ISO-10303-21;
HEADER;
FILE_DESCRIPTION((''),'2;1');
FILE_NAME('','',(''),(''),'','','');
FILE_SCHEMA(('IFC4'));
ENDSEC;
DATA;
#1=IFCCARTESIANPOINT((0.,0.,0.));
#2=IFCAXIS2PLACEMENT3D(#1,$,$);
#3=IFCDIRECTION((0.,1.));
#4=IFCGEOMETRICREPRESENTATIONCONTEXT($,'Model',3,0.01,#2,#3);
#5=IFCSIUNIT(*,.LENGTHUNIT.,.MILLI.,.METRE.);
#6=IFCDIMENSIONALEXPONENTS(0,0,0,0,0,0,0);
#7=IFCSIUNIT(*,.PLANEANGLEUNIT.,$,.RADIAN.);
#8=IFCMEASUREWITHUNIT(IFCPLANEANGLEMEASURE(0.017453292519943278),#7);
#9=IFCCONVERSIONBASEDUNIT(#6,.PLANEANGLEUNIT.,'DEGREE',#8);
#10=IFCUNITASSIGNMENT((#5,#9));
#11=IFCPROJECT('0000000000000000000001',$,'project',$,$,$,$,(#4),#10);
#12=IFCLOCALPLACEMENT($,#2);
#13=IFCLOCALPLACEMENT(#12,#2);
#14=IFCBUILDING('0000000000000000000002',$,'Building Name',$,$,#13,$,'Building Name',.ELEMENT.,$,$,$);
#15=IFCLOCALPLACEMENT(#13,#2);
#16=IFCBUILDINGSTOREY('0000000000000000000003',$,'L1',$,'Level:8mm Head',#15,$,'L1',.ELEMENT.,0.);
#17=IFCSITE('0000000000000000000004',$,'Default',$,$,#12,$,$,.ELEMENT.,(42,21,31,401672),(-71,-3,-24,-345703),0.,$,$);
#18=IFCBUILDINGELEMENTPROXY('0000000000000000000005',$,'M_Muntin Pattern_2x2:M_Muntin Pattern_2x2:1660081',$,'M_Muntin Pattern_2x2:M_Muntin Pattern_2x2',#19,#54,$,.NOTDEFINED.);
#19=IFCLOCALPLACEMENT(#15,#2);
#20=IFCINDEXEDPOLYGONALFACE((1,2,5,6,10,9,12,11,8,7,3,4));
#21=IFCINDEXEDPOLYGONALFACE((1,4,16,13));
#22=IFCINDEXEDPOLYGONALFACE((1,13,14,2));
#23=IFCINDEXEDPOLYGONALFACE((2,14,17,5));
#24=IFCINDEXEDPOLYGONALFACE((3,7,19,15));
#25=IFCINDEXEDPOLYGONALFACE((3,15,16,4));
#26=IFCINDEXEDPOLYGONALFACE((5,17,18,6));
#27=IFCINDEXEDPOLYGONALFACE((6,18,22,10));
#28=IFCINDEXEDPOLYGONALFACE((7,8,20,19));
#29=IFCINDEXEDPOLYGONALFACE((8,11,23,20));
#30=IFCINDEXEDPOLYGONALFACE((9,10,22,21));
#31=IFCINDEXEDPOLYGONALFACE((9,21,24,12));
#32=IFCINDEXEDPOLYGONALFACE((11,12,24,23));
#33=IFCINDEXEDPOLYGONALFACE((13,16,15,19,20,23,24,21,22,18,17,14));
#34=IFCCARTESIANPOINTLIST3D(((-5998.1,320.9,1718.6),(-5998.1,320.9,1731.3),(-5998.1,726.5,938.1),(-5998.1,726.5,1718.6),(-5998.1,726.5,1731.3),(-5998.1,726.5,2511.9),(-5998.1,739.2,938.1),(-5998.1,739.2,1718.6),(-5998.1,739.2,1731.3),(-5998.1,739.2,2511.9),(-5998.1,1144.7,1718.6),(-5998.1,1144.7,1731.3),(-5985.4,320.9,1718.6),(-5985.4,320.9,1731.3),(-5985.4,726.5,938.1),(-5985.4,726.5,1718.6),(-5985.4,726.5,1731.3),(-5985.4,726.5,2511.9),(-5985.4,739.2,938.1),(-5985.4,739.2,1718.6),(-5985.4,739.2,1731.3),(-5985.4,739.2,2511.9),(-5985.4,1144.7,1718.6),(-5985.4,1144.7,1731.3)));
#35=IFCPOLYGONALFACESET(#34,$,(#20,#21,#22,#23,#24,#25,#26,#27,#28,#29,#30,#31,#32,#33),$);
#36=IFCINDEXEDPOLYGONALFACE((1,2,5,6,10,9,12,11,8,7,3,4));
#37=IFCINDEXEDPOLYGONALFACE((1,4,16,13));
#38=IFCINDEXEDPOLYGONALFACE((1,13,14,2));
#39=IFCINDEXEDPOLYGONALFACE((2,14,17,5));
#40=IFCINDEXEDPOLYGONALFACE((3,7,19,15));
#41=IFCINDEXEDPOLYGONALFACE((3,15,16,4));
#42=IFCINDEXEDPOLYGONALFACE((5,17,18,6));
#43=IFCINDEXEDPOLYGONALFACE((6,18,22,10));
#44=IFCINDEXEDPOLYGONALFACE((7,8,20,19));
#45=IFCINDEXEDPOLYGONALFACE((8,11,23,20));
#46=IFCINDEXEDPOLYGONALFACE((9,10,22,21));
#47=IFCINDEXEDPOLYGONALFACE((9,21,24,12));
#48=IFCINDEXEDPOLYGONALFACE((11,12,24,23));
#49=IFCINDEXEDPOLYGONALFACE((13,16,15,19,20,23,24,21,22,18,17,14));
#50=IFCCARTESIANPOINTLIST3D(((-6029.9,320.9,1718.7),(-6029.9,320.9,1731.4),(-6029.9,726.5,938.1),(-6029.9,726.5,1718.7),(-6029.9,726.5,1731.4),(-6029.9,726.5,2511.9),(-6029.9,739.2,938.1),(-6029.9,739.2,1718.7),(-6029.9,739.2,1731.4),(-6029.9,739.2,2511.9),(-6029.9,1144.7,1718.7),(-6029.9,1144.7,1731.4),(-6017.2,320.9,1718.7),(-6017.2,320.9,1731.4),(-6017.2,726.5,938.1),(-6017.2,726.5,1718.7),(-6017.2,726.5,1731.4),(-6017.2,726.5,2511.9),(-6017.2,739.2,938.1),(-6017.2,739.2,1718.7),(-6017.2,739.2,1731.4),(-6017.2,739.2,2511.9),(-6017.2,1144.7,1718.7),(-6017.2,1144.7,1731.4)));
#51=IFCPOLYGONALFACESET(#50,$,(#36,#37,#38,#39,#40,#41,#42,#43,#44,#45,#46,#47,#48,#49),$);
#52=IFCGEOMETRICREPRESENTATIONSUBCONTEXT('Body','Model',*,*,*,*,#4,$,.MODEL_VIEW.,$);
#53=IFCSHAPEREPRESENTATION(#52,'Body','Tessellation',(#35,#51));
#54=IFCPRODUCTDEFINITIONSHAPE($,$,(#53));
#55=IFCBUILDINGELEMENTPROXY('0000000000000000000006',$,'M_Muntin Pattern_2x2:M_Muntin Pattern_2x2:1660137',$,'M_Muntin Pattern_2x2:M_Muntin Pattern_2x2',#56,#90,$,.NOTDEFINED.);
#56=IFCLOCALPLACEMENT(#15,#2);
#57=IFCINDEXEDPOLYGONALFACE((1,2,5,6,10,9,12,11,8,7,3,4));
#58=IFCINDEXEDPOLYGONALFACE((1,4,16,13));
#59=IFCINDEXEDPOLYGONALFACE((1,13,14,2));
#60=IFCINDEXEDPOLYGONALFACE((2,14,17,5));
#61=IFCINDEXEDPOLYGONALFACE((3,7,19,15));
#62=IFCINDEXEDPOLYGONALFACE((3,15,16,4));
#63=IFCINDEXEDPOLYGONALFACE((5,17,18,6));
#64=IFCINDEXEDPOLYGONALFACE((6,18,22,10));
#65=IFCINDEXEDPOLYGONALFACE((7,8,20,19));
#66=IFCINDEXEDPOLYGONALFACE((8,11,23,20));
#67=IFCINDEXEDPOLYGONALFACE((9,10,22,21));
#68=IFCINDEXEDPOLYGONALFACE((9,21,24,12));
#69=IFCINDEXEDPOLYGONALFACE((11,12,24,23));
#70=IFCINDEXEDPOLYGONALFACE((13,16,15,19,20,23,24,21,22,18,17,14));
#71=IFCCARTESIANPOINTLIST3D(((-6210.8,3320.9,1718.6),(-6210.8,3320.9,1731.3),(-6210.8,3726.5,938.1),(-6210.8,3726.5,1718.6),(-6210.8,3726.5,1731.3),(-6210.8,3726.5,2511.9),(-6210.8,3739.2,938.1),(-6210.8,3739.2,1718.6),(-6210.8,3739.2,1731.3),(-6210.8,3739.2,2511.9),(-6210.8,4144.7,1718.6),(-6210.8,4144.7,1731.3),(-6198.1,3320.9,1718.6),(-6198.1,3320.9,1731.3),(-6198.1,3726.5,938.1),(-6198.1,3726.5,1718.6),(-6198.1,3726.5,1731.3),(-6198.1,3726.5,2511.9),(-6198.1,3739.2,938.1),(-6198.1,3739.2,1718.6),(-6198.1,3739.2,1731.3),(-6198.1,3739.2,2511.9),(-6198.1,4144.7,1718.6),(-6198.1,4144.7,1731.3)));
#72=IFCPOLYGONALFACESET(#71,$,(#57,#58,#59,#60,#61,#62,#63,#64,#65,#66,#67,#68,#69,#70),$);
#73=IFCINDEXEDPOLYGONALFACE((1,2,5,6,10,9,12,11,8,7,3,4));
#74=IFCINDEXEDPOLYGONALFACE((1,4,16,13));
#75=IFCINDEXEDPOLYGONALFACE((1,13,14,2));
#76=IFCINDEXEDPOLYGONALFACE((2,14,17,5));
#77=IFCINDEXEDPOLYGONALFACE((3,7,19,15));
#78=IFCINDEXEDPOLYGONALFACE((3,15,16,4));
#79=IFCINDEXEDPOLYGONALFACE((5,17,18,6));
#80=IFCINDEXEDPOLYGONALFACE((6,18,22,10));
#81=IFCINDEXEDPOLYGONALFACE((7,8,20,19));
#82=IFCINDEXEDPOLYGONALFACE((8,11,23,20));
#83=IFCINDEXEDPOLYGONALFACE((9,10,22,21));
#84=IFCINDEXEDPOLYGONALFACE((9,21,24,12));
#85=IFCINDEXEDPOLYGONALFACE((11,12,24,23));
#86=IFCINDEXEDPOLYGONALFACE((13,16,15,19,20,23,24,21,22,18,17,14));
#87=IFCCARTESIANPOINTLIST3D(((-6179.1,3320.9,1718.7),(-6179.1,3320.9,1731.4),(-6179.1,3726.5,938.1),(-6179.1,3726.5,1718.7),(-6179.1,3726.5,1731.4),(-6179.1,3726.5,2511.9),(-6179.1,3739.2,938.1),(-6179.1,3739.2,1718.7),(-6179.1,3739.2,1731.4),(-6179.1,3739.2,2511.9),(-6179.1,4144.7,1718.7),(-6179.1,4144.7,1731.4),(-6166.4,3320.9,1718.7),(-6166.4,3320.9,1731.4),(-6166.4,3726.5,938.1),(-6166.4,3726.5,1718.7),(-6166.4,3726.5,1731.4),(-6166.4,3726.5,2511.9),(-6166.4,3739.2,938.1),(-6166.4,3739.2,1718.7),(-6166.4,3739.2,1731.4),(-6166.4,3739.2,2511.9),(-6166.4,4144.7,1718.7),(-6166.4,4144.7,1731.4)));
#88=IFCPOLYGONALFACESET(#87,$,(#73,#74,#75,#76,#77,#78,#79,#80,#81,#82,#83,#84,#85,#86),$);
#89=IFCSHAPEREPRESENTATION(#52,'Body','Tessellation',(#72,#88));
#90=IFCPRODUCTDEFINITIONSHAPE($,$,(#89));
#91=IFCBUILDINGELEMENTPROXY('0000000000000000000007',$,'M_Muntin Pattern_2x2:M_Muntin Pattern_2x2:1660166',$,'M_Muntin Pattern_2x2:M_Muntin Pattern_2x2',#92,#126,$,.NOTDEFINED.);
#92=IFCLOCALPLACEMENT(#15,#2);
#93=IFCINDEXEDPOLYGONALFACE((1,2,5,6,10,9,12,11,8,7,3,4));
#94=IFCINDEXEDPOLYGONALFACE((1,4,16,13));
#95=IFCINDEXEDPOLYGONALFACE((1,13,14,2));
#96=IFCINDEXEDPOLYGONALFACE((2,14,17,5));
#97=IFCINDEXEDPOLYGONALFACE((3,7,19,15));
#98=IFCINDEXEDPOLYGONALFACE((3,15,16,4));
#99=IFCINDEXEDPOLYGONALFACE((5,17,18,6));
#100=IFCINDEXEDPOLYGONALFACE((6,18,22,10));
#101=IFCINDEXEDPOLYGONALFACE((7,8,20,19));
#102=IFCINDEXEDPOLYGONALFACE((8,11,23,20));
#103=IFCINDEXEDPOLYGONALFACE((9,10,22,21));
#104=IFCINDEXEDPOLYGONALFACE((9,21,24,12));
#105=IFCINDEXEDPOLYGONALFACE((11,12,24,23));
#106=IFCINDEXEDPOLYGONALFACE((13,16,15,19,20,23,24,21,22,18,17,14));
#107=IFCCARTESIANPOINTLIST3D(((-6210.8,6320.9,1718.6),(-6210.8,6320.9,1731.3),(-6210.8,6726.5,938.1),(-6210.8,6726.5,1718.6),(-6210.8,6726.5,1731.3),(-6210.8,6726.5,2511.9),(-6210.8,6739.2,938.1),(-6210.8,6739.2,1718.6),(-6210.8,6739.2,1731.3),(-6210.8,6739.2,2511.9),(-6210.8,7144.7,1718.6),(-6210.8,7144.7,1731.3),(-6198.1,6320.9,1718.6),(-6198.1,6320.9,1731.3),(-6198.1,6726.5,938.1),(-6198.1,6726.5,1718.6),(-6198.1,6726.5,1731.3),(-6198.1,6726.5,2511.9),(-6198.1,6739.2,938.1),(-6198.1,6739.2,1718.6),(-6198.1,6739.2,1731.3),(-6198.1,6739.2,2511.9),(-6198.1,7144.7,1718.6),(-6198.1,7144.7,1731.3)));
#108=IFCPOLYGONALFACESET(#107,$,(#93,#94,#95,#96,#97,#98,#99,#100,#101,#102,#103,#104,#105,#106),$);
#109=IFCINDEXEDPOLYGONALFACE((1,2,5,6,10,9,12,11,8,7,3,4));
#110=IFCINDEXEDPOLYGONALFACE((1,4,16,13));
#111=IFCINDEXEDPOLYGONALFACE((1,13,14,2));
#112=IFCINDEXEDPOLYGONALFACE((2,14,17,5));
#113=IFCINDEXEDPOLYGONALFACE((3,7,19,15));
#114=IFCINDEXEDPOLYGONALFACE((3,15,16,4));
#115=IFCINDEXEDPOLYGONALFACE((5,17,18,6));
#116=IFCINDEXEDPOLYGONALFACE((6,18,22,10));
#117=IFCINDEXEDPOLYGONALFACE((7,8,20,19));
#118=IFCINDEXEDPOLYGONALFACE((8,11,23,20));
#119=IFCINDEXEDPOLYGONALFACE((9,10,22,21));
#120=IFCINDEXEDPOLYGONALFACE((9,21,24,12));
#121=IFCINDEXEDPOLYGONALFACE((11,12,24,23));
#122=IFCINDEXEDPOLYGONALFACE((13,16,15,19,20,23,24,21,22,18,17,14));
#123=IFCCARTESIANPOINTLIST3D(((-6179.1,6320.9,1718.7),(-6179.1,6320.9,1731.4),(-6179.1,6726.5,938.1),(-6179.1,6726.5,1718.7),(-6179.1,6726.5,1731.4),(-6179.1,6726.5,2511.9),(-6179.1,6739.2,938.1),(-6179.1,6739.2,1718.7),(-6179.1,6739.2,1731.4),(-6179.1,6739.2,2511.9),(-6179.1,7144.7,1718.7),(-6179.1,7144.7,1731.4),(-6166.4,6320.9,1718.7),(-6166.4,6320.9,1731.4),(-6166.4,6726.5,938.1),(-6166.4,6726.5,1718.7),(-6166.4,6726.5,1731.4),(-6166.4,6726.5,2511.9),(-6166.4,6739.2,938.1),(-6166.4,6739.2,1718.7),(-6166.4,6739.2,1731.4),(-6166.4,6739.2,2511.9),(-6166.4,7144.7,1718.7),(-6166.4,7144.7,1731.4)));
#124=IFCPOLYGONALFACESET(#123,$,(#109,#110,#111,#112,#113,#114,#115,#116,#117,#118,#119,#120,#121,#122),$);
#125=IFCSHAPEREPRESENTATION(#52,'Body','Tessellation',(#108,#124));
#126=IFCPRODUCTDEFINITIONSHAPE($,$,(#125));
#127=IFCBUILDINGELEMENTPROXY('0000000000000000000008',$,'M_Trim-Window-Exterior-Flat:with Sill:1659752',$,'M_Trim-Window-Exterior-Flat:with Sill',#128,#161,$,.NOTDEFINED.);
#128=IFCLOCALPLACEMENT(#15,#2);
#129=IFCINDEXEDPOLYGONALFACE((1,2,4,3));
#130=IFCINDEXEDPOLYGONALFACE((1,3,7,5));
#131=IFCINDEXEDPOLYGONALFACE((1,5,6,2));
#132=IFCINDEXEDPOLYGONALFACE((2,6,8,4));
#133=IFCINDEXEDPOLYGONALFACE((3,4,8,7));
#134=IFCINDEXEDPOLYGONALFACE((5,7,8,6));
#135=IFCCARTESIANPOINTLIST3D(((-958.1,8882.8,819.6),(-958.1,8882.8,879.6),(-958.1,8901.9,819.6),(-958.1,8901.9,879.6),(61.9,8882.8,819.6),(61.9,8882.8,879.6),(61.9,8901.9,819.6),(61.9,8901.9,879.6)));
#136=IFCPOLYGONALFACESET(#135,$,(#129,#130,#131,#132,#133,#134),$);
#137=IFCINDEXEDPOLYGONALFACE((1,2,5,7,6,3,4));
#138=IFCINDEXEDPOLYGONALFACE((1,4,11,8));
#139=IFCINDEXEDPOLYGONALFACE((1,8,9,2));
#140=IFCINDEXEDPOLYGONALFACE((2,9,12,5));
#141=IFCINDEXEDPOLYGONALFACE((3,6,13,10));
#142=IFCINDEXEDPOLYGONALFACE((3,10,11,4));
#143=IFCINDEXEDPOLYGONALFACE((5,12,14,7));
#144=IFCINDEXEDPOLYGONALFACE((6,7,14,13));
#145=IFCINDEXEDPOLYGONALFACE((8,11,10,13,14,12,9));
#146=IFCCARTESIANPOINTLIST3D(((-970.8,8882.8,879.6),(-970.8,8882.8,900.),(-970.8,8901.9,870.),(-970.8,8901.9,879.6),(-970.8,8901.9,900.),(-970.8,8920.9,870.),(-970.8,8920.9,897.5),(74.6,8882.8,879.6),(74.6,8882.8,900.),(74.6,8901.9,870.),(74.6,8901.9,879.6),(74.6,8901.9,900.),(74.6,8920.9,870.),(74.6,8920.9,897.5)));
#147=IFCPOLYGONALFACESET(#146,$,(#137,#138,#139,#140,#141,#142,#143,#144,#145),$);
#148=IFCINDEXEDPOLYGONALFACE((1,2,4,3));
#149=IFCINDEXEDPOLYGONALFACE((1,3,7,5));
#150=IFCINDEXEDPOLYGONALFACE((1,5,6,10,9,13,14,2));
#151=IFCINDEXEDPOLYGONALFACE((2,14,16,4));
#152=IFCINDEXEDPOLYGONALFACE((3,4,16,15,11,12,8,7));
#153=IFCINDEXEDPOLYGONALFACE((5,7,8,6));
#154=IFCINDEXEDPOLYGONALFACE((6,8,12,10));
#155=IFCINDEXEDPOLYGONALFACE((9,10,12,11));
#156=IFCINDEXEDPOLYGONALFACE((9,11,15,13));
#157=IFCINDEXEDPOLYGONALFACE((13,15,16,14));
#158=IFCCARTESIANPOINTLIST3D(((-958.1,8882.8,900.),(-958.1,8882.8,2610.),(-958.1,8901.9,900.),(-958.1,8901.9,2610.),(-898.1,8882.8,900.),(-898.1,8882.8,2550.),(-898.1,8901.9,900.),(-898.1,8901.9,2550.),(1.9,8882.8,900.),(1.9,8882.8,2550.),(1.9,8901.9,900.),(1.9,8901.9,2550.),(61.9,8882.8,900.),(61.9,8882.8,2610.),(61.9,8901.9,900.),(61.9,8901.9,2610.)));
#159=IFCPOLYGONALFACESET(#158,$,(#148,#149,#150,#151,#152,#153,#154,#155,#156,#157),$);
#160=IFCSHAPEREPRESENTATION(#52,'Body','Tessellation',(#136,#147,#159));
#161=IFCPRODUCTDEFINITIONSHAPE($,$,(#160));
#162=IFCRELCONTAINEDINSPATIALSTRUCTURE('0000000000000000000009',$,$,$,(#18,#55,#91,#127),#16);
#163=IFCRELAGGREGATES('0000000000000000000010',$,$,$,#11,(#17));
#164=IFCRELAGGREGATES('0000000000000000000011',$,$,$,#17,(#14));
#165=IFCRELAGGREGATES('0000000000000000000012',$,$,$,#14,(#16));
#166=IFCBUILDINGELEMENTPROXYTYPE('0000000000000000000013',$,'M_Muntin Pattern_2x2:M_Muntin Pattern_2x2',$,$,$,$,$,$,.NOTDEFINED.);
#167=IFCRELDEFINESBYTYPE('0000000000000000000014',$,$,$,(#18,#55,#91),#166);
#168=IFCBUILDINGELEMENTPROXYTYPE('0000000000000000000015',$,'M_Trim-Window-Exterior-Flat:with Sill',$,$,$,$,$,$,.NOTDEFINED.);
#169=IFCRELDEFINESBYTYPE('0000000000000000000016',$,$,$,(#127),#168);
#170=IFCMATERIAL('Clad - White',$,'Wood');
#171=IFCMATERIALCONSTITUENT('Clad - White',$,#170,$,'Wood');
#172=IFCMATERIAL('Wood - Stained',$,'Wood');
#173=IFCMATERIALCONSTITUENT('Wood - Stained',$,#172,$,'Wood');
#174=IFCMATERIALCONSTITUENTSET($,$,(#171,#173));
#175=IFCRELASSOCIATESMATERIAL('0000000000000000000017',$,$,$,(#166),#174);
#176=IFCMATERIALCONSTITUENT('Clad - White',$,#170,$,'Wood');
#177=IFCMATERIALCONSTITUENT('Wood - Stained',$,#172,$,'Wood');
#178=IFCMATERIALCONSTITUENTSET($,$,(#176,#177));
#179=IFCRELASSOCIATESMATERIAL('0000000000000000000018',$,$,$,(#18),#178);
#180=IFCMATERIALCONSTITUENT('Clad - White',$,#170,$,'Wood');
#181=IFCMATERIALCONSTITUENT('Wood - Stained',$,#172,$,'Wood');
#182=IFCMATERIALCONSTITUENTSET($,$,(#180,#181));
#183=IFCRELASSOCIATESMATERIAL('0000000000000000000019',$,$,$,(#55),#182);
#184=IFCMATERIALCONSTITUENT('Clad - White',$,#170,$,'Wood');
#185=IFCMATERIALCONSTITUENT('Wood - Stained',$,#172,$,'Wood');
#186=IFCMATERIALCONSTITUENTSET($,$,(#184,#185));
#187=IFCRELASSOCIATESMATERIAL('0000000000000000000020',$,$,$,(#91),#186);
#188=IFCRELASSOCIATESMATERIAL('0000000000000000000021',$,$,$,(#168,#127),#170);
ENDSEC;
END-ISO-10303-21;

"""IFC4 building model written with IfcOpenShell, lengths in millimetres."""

from ifc_helpers import new_model, entity, si_unit, converted_unit, direction, frame, origin, place, context, subcontext, project, spatial, indexed_curve, outline, extrude, source, transform, mapped, material, constituent, constituent_set, type_object, type_shapes, element, save


model = new_model("IFC4")

# Units and contexts
model_context = context("Model", 3, precision=0.01, world=origin(), true_north=direction((0.0, 1.0)))
body_context = subcontext(model_context, "Body", "Model", "MODEL_VIEW")
ifc_project = project(units=[si_unit("LENGTHUNIT", "METRE", prefix="MILLI"), converted_unit("PLANEANGLEUNIT", "DEGREE", entity("IfcPlaneAngleMeasure", 0.017453292519943278), si_unit("PLANEANGLEUNIT", "RADIAN"), dimensions=[0, 0, 0, 0, 0, 0, 0])], contexts=[model_context])

# Site, building, storey
site_placement = place(None, origin())
site = spatial("IfcSite", under=ifc_project, at=site_placement, Name="Default", CompositionType="ELEMENT", RefLatitude=(42, 21, 31, 401672), RefLongitude=(-71, -3, -24, -345703), RefElevation=0.0)
building_placement = place(site_placement, origin())
building = spatial("IfcBuilding", under=site, at=building_placement, Name="Building Name", LongName="Building Name", CompositionType="ELEMENT")
storey_placement = place(building_placement, origin())
storey = spatial("IfcBuildingStorey", under=building, at=storey_placement, Name="L1", ObjectType="Level:8mm Head", LongName="L1", CompositionType="ELEMENT", Elevation=0.0)

# Building element proxies
ifc_material_1 = material(Name="Clad - White", Category="Wood")
ifc_material_2 = material(Name="Wood - Stained", Category="Wood")
ifc_constituent_1 = constituent(ifc_material_1, Name="Clad - White", Category="Wood")
ifc_constituent_2 = constituent(ifc_material_2, Name="Wood - Stained", Category="Wood")
ifc_constituent_set_1 = constituent_set(constituents=[ifc_constituent_1, ifc_constituent_2])
building_element_proxy_type_1 = type_object("IfcBuildingElementProxyType", Name="M_Muntin Pattern_2x2:M_Muntin Pattern_2x2", PredefinedType="NOTDEFINED", material=ifc_constituent_set_1)
shared_shape_1 = source(origin(), body_context, "Body", "SweptSolid", [
    extrude(outline(indexed_curve([(6.4, -6.4), (786.9, -6.4), (786.9, 6.3), (6.4, 6.3), (6.4, 411.9), (-6.3, 411.9), (-6.3, 6.3), (-786.9, 6.3), (-786.9, -6.4), (-6.3, -6.4), (-6.3, -411.9), (6.4, -411.9), (6.4, -6.4)], self_intersect=False)), frame((0.0, -22.2, 786.9), z_axis=(0.0, 1.0, 0.0), x_axis=(0.0, 0.0, 1.0)), (0.0, 0.0, 1.0), 12.7),
    extrude(outline(indexed_curve([(6.4, -6.4), (786.9, -6.4), (786.9, 6.3), (6.4, 6.3), (6.4, 411.9), (-6.3, 411.9), (-6.3, 6.3), (-786.9, 6.3), (-786.9, -6.4), (-6.3, -6.4), (-6.3, -411.9), (6.4, -411.9), (6.4, -6.4)], self_intersect=False)), frame((0.0, 9.5, 786.9), z_axis=(0.0, 1.0, 0.0), x_axis=(0.0, 0.0, 1.0)), (0.0, 0.0, 1.0), 12.7),
])
type_shapes(building_element_proxy_type_1, [shared_shape_1])
ifc_constituent_3 = constituent(ifc_material_1, Name="Clad - White", Category="Wood")
ifc_constituent_4 = constituent(ifc_material_2, Name="Wood - Stained", Category="Wood")
ifc_constituent_set_2 = constituent_set(constituents=[ifc_constituent_3, ifc_constituent_4])
proxy_1_placement = place(storey_placement, frame((-6007.6, 732.8, 938.1), z_axis=(0.0, 0.0, 1.0), x_axis=(0.0, 1.0, 0.0)))
element("IfcBuildingElementProxy", 1, at=proxy_1_placement, inside=storey, type_object=building_element_proxy_type_1, material=ifc_constituent_set_2, Name="M_Muntin Pattern_2x2:M_Muntin Pattern_2x2:1660081", ObjectType="M_Muntin Pattern_2x2:M_Muntin Pattern_2x2", PredefinedType="NOTDEFINED", context=body_context, shape_type="MappedRepresentation", body=[
    mapped(shared_shape_1, transform((0.0, 0.0, 0.0), scale=1.0)),
])
ifc_constituent_5 = constituent(ifc_material_1, Name="Clad - White", Category="Wood")
ifc_constituent_6 = constituent(ifc_material_2, Name="Wood - Stained", Category="Wood")
ifc_constituent_set_3 = constituent_set(constituents=[ifc_constituent_5, ifc_constituent_6])
proxy_2_placement = place(storey_placement, frame((-6188.6, 3732.8, 938.1), z_axis=(0.0, 0.0, 1.0), x_axis=(0.0, -1.0, 0.0)))
element("IfcBuildingElementProxy", 2, at=proxy_2_placement, inside=storey, type_object=building_element_proxy_type_1, material=ifc_constituent_set_3, Name="M_Muntin Pattern_2x2:M_Muntin Pattern_2x2:1660137", ObjectType="M_Muntin Pattern_2x2:M_Muntin Pattern_2x2", PredefinedType="NOTDEFINED", context=body_context, shape_type="MappedRepresentation", body=[
    mapped(shared_shape_1, transform((0.0, 0.0, 0.0), scale=1.0)),
])
ifc_constituent_7 = constituent(ifc_material_1, Name="Clad - White", Category="Wood")
ifc_constituent_8 = constituent(ifc_material_2, Name="Wood - Stained", Category="Wood")
ifc_constituent_set_4 = constituent_set(constituents=[ifc_constituent_7, ifc_constituent_8])
proxy_3_placement = place(storey_placement, frame((-6188.6, 6732.8, 938.1), z_axis=(0.0, 0.0, 1.0), x_axis=(0.0, -1.0, 0.0)))
element("IfcBuildingElementProxy", 3, at=proxy_3_placement, inside=storey, type_object=building_element_proxy_type_1, material=ifc_constituent_set_4, Name="M_Muntin Pattern_2x2:M_Muntin Pattern_2x2:1660166", ObjectType="M_Muntin Pattern_2x2:M_Muntin Pattern_2x2", PredefinedType="NOTDEFINED", context=body_context, shape_type="MappedRepresentation", body=[
    mapped(shared_shape_1, transform((0.0, 0.0, 0.0), scale=1.0)),
])
building_element_proxy_type_2 = type_object("IfcBuildingElementProxyType", Name="M_Trim-Window-Exterior-Flat:with Sill", PredefinedType="NOTDEFINED", material=ifc_material_1)
shared_shape_2 = source(origin(), body_context, "Body", "SweptSolid", [
    extrude(outline(indexed_curve([(-510.0, -30.0), (510.0, -30.0), (510.0, 30.0), (-510.0, 30.0), (-510.0, -30.0)], self_intersect=False)), frame((0.0, -1700.4, 0.0), z_axis=(0.0, 0.0, 1.0), x_axis=(-1.0, 0.0, 0.0)), (0.0, 0.0, 1.0), 19.0),
    extrude(outline(indexed_curve([(-19.0, -15.2), (0.0, -15.2), (0.0, -5.7), (19.0, -5.7), (19.0, 14.8), (0.0, 14.8), (-19.0, 12.3), (-19.0, -15.2)], self_intersect=False)), frame((-522.7, -1664.8, 19.0), z_axis=(1.0, 0.0, 0.0), x_axis=(0.0, 0.0, -1.0)), (0.0, 0.0, 1.0), 1045.4),
    extrude(outline(indexed_curve([(-870.0, -510.0), (840.0, -510.0), (840.0, -450.0), (-810.0, -450.0), (-810.0, 450.0), (840.0, 450.0), (840.0, 510.0), (-870.0, 510.0), (-870.0, -510.0)], self_intersect=False)), frame((0.0, -810.0, 0.0), z_axis=(0.0, 0.0, 1.0), x_axis=(0.0, -1.0, 0.0)), (0.0, 0.0, 1.0), 19.0),
])
type_shapes(building_element_proxy_type_2, [shared_shape_2])
for number, where, z_axis, x_axis, name in (
    (4, (-448.1, 8882.8, 2550.0), (0.0, 1.0, 0.0), (-1.0, 0.0, 0.0), "M_Trim-Window-Exterior-Flat:with Sill:1659752"),
):
    element("IfcBuildingElementProxy", number, at=place(storey_placement, frame(where, z_axis=z_axis, x_axis=x_axis)), inside=storey, type_object=building_element_proxy_type_2, material=ifc_material_1, Name=name, ObjectType="M_Trim-Window-Exterior-Flat:with Sill", PredefinedType="NOTDEFINED", context=body_context, shape_type="MappedRepresentation", body=[
        mapped(shared_shape_2, transform((0.0, 0.0, 0.0), scale=1.0)),
    ])

save(model, "model.ifc")
